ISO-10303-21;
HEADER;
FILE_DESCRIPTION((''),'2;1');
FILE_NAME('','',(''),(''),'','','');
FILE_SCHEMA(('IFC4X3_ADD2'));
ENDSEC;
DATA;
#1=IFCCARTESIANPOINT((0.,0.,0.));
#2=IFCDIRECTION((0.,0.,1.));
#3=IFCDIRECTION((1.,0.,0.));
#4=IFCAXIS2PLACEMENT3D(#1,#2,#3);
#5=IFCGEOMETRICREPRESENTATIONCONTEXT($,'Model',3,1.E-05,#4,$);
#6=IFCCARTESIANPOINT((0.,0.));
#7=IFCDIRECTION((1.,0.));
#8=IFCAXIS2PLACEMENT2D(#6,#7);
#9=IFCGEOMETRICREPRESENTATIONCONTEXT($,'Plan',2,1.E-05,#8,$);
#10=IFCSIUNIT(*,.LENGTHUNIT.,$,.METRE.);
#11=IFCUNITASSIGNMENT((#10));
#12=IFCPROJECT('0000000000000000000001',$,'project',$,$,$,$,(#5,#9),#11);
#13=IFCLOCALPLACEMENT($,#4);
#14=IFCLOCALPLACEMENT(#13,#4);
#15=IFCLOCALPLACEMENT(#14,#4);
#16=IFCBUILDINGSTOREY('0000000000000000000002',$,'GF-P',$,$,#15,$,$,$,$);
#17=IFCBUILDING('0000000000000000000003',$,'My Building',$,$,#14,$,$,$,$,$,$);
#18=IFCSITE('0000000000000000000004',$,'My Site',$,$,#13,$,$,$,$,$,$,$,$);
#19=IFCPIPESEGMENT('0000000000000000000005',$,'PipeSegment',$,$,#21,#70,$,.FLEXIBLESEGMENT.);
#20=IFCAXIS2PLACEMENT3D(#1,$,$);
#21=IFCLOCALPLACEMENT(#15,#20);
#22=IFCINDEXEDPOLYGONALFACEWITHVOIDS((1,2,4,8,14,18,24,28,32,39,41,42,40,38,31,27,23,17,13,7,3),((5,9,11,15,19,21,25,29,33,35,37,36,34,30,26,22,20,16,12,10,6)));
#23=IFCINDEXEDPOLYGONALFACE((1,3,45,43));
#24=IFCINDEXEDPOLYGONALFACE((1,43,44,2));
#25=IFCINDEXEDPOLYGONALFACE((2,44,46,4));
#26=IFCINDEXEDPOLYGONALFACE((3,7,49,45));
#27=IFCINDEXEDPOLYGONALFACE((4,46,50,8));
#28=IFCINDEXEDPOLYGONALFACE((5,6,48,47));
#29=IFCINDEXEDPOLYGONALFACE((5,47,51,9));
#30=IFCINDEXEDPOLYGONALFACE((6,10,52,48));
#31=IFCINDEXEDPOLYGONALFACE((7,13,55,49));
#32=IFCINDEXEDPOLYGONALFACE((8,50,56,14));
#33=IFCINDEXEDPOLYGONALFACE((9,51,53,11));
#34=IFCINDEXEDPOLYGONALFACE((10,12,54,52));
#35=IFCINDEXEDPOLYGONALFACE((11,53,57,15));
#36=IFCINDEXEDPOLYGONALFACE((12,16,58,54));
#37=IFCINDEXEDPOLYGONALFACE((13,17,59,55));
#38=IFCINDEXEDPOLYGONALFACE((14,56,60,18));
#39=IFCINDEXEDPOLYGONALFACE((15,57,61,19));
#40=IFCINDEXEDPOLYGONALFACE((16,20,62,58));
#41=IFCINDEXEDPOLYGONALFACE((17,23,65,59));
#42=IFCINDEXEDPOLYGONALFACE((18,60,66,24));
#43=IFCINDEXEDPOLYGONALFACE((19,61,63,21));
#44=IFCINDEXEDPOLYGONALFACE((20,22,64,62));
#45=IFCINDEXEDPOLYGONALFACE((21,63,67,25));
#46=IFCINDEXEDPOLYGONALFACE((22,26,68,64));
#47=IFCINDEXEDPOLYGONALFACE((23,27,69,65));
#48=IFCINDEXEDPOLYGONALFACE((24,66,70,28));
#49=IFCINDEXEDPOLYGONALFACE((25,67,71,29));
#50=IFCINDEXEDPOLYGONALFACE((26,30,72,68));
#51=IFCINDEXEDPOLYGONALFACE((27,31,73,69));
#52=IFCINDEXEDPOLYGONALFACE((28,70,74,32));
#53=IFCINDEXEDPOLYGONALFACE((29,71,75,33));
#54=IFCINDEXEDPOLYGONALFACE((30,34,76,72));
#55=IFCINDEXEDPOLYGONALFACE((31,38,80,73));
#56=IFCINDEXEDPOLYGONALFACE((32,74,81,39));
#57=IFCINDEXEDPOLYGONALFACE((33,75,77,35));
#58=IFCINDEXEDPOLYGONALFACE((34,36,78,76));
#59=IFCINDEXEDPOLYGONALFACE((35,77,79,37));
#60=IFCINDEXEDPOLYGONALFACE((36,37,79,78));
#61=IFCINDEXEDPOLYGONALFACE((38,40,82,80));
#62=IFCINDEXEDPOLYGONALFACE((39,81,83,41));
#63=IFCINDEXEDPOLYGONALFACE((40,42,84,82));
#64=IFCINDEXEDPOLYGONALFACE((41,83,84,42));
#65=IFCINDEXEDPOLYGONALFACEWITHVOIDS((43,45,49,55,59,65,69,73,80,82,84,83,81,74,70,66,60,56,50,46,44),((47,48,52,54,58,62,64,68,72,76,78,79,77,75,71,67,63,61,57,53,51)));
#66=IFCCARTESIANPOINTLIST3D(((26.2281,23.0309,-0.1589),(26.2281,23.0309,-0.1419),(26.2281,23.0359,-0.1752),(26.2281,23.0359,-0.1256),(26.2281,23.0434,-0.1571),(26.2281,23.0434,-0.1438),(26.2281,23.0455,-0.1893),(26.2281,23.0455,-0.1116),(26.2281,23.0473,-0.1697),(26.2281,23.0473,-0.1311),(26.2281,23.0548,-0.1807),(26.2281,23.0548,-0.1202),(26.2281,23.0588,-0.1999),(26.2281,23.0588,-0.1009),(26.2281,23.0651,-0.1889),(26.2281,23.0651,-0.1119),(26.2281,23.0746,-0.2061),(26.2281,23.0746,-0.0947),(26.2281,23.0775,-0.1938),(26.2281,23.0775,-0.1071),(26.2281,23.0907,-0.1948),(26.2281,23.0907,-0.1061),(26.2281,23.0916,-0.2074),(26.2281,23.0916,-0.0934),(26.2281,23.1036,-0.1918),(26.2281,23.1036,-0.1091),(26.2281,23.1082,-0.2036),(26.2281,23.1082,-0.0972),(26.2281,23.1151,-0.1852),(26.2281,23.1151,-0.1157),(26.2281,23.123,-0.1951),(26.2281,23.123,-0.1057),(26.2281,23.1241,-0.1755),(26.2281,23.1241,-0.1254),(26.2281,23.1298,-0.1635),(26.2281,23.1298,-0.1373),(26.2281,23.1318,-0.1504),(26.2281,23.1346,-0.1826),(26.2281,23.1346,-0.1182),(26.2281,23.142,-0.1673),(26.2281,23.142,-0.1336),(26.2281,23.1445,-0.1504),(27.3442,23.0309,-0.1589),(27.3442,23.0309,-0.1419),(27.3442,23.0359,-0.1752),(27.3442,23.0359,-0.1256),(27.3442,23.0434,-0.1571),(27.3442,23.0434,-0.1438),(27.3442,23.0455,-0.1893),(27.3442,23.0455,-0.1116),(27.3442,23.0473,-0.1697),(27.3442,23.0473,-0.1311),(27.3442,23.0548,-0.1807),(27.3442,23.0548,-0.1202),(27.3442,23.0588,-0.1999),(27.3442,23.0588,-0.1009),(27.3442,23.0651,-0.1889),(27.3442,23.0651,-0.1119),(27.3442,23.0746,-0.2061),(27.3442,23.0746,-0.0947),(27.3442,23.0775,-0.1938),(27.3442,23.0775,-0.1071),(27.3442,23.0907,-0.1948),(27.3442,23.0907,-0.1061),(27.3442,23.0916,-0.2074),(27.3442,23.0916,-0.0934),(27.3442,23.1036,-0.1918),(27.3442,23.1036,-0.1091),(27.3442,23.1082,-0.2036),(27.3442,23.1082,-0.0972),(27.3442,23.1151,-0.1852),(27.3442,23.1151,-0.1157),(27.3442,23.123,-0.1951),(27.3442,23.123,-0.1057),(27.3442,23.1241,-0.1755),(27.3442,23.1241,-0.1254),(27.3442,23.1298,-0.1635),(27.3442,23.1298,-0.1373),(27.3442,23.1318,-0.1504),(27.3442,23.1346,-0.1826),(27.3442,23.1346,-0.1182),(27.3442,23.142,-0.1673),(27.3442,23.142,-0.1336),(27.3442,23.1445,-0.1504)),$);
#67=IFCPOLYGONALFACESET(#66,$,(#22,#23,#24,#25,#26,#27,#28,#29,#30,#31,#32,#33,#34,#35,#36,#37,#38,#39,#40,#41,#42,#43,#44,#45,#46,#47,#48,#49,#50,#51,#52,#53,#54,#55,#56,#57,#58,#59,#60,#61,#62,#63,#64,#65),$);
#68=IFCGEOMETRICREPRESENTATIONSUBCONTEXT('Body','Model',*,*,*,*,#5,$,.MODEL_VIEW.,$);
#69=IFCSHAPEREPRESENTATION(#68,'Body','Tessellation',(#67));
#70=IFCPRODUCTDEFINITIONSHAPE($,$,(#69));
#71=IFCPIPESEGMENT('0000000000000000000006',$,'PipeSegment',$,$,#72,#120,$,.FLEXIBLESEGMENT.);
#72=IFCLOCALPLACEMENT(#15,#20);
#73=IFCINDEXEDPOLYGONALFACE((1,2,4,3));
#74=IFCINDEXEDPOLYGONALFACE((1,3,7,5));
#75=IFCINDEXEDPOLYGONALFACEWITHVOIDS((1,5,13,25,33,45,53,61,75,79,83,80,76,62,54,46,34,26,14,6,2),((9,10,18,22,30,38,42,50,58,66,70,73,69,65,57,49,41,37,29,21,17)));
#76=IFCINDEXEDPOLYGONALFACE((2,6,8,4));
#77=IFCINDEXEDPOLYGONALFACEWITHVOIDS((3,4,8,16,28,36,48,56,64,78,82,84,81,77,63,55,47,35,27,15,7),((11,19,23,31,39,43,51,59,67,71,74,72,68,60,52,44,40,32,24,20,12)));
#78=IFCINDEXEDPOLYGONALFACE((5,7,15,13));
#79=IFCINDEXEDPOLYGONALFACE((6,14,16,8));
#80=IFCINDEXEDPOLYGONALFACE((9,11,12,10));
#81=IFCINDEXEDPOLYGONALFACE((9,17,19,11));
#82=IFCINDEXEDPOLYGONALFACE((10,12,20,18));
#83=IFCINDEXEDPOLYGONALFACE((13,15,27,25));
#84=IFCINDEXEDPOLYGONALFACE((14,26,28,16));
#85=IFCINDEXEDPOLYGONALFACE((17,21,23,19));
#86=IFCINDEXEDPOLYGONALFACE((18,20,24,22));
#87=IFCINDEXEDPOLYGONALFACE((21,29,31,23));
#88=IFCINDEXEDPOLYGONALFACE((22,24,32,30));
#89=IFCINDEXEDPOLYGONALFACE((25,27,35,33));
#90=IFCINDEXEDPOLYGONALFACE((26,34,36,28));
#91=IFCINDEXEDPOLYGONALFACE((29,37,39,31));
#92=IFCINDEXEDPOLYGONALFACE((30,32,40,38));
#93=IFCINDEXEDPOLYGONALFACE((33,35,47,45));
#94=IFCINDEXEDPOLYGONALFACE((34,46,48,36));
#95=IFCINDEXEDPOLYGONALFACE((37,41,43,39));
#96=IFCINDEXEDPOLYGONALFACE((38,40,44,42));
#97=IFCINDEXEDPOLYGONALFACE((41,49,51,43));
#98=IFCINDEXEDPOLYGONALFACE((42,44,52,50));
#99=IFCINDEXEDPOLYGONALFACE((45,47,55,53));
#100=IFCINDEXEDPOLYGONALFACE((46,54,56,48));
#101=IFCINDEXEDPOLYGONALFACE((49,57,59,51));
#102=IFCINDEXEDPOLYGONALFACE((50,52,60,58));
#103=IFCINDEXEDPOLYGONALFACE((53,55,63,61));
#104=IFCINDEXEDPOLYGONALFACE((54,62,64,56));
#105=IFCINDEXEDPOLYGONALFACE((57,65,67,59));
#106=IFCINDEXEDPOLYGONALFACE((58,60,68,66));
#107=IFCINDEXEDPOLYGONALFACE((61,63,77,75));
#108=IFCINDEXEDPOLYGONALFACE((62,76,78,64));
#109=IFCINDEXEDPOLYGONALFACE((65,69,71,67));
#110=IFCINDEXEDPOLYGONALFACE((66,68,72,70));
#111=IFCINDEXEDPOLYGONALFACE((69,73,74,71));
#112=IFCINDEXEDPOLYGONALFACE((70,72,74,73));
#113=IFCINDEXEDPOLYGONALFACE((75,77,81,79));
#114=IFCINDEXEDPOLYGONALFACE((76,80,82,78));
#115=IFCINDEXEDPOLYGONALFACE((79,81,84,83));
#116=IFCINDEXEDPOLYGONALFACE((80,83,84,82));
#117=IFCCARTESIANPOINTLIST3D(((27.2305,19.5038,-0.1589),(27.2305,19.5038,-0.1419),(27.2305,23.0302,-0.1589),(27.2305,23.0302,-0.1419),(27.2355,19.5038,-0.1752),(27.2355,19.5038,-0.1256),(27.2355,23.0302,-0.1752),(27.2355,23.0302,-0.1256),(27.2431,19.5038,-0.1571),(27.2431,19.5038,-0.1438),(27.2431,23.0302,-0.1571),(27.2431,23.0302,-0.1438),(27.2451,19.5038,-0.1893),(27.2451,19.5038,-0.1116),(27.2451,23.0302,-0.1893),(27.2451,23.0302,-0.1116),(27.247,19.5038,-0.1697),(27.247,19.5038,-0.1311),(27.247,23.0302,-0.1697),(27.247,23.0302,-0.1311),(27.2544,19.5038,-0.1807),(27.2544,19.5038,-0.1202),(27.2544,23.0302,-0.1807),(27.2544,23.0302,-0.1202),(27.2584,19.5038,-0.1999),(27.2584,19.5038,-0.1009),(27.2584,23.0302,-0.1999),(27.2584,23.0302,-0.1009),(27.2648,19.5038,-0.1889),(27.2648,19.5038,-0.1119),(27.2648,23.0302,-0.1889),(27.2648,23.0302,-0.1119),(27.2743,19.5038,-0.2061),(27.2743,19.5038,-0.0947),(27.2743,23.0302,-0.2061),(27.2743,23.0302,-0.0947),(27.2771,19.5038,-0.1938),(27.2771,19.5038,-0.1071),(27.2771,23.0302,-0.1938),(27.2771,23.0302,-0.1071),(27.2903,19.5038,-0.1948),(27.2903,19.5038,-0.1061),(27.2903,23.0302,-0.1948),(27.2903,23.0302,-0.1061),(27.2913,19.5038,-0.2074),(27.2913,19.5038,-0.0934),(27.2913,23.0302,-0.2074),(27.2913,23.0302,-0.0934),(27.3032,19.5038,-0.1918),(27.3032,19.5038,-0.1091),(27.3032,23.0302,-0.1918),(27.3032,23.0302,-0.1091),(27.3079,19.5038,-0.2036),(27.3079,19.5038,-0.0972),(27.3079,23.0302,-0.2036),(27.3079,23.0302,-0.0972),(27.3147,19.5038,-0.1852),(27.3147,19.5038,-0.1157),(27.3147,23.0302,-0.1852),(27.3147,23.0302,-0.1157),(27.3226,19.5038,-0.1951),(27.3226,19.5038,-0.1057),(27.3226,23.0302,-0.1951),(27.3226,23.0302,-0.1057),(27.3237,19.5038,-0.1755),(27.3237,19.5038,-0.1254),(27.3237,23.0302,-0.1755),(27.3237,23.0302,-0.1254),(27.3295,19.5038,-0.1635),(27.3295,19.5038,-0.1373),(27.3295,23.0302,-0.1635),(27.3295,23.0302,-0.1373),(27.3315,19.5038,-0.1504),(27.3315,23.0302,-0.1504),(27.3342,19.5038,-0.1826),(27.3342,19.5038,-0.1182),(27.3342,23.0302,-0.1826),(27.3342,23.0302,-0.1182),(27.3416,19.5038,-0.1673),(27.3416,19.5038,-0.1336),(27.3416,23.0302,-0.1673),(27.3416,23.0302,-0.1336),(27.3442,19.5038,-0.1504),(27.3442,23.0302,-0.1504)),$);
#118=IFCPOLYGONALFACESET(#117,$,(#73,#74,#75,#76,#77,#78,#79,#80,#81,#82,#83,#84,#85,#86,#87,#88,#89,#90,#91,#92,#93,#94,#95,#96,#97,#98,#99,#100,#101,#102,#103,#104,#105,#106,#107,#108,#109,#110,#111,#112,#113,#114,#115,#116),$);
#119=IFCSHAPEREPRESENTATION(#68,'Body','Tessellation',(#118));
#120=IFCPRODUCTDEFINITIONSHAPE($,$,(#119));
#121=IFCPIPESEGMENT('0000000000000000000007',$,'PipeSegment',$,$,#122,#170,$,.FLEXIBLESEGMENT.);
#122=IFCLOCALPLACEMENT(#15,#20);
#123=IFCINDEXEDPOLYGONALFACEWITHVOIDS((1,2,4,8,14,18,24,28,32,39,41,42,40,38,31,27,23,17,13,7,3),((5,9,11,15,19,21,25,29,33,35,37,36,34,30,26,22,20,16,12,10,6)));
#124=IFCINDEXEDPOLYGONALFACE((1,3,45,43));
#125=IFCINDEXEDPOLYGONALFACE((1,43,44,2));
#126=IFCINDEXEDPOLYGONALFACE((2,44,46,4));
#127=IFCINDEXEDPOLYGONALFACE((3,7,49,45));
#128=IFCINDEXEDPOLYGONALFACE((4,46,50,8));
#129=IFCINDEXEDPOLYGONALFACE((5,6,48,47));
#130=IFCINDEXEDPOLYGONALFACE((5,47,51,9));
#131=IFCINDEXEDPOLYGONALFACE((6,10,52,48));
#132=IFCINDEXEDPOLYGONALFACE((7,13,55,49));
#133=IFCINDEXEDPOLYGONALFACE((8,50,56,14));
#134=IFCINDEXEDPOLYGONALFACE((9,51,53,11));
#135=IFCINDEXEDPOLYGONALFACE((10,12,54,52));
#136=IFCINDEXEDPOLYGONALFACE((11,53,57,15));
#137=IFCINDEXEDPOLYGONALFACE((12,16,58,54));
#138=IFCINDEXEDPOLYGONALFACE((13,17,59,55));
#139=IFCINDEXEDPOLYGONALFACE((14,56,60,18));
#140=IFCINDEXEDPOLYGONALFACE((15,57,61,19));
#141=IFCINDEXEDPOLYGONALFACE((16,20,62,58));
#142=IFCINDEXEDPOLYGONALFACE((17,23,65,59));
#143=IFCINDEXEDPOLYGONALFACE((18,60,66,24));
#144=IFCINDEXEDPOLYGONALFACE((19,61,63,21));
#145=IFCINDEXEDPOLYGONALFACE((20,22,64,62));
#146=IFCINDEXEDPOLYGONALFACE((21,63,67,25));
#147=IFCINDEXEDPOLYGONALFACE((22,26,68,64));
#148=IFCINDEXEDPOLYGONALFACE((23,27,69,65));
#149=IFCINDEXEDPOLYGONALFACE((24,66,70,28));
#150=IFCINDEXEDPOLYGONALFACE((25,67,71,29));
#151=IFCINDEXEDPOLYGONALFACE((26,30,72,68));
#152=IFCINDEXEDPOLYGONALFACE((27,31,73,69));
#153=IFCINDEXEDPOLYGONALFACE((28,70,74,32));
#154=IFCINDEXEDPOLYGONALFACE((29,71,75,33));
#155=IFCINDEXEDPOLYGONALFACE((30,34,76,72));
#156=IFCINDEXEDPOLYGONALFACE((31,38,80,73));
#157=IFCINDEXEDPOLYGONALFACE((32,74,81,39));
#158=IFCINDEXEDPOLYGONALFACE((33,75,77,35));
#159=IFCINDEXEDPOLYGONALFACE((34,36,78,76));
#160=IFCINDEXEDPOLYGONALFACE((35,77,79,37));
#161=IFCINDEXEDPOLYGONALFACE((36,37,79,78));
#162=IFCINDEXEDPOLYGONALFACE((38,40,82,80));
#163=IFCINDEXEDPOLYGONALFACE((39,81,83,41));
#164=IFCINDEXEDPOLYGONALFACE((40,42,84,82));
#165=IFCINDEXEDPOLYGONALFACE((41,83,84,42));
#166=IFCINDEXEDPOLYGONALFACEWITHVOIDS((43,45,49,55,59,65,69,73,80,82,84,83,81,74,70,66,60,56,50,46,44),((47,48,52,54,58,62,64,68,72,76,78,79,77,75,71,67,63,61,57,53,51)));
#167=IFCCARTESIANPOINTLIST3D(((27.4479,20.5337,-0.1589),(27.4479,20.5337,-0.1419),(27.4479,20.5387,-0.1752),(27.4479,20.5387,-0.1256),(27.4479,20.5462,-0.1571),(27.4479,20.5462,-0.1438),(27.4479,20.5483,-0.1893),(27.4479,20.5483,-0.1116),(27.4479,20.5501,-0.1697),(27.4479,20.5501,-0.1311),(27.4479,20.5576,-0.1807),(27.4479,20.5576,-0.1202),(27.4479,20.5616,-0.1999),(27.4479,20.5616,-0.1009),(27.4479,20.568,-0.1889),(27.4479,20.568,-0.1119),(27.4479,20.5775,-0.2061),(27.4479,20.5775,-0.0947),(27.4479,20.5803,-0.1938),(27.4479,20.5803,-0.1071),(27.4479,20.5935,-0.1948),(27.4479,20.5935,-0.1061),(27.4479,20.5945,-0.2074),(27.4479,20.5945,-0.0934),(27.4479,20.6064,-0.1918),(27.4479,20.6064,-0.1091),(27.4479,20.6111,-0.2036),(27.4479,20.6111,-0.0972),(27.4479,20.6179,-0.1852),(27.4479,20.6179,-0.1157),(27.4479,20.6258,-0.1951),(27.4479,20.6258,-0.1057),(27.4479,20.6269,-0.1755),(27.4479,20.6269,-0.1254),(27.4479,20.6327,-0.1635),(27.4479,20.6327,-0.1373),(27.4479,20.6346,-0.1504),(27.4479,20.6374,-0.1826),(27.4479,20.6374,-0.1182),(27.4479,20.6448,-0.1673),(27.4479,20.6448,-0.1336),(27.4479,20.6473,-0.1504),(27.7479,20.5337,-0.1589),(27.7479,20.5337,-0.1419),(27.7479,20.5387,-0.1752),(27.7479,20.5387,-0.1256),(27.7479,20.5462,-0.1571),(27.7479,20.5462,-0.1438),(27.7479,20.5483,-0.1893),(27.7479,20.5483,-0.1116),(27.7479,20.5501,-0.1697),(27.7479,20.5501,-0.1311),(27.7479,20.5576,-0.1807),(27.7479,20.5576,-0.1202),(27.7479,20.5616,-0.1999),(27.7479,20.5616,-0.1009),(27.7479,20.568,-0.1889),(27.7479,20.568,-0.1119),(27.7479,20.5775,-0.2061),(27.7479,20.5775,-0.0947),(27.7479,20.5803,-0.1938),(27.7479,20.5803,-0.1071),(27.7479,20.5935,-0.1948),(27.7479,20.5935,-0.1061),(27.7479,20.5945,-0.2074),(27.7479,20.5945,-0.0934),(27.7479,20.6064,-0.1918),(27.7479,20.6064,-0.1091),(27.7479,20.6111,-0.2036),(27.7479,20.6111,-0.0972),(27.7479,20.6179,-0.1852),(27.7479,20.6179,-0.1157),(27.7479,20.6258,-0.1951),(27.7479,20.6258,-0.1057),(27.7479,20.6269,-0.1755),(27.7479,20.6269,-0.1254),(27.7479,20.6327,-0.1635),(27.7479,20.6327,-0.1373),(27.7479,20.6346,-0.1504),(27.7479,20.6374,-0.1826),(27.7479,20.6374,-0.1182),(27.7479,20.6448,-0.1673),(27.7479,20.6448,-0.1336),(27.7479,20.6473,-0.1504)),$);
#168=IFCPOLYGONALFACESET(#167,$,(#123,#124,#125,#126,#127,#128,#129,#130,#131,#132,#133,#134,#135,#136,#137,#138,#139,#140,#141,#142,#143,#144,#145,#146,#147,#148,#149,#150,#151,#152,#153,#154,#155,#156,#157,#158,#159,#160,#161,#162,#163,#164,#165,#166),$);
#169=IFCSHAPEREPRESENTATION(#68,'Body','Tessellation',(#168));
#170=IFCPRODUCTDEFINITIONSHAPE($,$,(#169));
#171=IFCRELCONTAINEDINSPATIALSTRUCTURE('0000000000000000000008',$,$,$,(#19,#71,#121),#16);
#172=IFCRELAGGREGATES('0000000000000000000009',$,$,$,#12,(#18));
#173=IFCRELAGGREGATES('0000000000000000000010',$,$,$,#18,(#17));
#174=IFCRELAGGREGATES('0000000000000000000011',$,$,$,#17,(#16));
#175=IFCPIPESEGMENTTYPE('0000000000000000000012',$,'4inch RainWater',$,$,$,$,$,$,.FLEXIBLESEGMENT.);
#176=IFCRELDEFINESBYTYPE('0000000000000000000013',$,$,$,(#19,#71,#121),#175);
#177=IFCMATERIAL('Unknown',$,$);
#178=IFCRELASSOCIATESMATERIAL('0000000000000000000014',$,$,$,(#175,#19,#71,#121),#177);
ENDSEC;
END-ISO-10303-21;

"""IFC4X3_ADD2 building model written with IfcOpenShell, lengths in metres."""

from ifc_helpers import new_model, si_unit, frame, origin_with_axes, origin_2d_with_axis, place, context, subcontext, project, spatial, hollow_circle, extrude, material, material_profile, profile_set, profile_usage, type_object, element, save


model = new_model("IFC4X3_ADD2")

# Units and contexts
model_context = context("Model", 3, precision=1e-05, world=origin_with_axes())
plan_context = context("Plan", 2, precision=1e-05, world=origin_2d_with_axis())
body_context = subcontext(model_context, "Body", "Model", "MODEL_VIEW")
ifc_project = project(units=[si_unit("LENGTHUNIT", "METRE")], contexts=[model_context, plan_context])

# Site, building, storey
site_placement = place(None, origin_with_axes())
site = spatial("IfcSite", under=ifc_project, at=site_placement, Name="My Site")
building_placement = place(site_placement, origin_with_axes())
building = spatial("IfcBuilding", under=site, at=building_placement, Name="My Building")
storey_placement = place(building_placement, origin_with_axes())
storey = spatial("IfcBuildingStorey", under=building, at=storey_placement, Name="GF-P")

# Pipe segments
ifc_material_1 = material(Name="Unknown")
ifc_material_profile_1 = material_profile(ifc_material_1, hollow_circle(Radius=0.0571, WallThickness=0.0127))
ifc_profile_set_1 = profile_set([ifc_material_profile_1], Name="rainwater")
pipe_segment_type_1 = type_object("IfcPipeSegmentType", Name="4inch RainWater", PredefinedType="FLEXIBLESEGMENT", material=ifc_profile_set_1)
ifc_profile_usage_1 = profile_usage(ifc_profile_set_1)
pipe_segment_1_placement = place(storey_placement, frame((26.2281, 23.0874, -0.1504), z_axis=(1.0, 0.0, 0.0), x_axis=(0.0, 1.0, 0.0)))
element("IfcPipeSegment", 1, at=pipe_segment_1_placement, inside=storey, type_object=pipe_segment_type_1, material=ifc_profile_usage_1, Name="PipeSegment", PredefinedType="FLEXIBLESEGMENT", context=body_context, shape_type="SweptSolid", body=[
    extrude(hollow_circle(Radius=0.0571, WallThickness=0.0127), origin_with_axes(), (0.0, 0.0, 1.0), 1.116),
])
ifc_profile_usage_2 = profile_usage(ifc_profile_set_1)
pipe_segment_2_placement = place(storey_placement, frame((27.287, 23.0302, -0.1504), z_axis=(0.0, -1.0, 0.0), x_axis=(1.0, 0.0, 0.0)))
element("IfcPipeSegment", 2, at=pipe_segment_2_placement, inside=storey, type_object=pipe_segment_type_1, material=ifc_profile_usage_2, Name="PipeSegment", PredefinedType="FLEXIBLESEGMENT", context=body_context, shape_type="SweptSolid", body=[
    extrude(hollow_circle(Radius=0.0571, WallThickness=0.0127), origin_with_axes(), (0.0, 0.0, 1.0), 3.5264),
])
ifc_profile_usage_3 = profile_usage(ifc_profile_set_1)
pipe_segment_3_placement = place(storey_placement, frame((27.4479, 20.5902, -0.1504), z_axis=(1.0, 0.0, 0.0), x_axis=(0.0, 1.0, 0.0)))
element("IfcPipeSegment", 3, at=pipe_segment_3_placement, inside=storey, type_object=pipe_segment_type_1, material=ifc_profile_usage_3, Name="PipeSegment", PredefinedType="FLEXIBLESEGMENT", context=body_context, shape_type="SweptSolid", body=[
    extrude(hollow_circle(Radius=0.0571, WallThickness=0.0127), origin_with_axes(), (0.0, 0.0, 1.0), 0.3),
])

save(model, "model.ifc")
